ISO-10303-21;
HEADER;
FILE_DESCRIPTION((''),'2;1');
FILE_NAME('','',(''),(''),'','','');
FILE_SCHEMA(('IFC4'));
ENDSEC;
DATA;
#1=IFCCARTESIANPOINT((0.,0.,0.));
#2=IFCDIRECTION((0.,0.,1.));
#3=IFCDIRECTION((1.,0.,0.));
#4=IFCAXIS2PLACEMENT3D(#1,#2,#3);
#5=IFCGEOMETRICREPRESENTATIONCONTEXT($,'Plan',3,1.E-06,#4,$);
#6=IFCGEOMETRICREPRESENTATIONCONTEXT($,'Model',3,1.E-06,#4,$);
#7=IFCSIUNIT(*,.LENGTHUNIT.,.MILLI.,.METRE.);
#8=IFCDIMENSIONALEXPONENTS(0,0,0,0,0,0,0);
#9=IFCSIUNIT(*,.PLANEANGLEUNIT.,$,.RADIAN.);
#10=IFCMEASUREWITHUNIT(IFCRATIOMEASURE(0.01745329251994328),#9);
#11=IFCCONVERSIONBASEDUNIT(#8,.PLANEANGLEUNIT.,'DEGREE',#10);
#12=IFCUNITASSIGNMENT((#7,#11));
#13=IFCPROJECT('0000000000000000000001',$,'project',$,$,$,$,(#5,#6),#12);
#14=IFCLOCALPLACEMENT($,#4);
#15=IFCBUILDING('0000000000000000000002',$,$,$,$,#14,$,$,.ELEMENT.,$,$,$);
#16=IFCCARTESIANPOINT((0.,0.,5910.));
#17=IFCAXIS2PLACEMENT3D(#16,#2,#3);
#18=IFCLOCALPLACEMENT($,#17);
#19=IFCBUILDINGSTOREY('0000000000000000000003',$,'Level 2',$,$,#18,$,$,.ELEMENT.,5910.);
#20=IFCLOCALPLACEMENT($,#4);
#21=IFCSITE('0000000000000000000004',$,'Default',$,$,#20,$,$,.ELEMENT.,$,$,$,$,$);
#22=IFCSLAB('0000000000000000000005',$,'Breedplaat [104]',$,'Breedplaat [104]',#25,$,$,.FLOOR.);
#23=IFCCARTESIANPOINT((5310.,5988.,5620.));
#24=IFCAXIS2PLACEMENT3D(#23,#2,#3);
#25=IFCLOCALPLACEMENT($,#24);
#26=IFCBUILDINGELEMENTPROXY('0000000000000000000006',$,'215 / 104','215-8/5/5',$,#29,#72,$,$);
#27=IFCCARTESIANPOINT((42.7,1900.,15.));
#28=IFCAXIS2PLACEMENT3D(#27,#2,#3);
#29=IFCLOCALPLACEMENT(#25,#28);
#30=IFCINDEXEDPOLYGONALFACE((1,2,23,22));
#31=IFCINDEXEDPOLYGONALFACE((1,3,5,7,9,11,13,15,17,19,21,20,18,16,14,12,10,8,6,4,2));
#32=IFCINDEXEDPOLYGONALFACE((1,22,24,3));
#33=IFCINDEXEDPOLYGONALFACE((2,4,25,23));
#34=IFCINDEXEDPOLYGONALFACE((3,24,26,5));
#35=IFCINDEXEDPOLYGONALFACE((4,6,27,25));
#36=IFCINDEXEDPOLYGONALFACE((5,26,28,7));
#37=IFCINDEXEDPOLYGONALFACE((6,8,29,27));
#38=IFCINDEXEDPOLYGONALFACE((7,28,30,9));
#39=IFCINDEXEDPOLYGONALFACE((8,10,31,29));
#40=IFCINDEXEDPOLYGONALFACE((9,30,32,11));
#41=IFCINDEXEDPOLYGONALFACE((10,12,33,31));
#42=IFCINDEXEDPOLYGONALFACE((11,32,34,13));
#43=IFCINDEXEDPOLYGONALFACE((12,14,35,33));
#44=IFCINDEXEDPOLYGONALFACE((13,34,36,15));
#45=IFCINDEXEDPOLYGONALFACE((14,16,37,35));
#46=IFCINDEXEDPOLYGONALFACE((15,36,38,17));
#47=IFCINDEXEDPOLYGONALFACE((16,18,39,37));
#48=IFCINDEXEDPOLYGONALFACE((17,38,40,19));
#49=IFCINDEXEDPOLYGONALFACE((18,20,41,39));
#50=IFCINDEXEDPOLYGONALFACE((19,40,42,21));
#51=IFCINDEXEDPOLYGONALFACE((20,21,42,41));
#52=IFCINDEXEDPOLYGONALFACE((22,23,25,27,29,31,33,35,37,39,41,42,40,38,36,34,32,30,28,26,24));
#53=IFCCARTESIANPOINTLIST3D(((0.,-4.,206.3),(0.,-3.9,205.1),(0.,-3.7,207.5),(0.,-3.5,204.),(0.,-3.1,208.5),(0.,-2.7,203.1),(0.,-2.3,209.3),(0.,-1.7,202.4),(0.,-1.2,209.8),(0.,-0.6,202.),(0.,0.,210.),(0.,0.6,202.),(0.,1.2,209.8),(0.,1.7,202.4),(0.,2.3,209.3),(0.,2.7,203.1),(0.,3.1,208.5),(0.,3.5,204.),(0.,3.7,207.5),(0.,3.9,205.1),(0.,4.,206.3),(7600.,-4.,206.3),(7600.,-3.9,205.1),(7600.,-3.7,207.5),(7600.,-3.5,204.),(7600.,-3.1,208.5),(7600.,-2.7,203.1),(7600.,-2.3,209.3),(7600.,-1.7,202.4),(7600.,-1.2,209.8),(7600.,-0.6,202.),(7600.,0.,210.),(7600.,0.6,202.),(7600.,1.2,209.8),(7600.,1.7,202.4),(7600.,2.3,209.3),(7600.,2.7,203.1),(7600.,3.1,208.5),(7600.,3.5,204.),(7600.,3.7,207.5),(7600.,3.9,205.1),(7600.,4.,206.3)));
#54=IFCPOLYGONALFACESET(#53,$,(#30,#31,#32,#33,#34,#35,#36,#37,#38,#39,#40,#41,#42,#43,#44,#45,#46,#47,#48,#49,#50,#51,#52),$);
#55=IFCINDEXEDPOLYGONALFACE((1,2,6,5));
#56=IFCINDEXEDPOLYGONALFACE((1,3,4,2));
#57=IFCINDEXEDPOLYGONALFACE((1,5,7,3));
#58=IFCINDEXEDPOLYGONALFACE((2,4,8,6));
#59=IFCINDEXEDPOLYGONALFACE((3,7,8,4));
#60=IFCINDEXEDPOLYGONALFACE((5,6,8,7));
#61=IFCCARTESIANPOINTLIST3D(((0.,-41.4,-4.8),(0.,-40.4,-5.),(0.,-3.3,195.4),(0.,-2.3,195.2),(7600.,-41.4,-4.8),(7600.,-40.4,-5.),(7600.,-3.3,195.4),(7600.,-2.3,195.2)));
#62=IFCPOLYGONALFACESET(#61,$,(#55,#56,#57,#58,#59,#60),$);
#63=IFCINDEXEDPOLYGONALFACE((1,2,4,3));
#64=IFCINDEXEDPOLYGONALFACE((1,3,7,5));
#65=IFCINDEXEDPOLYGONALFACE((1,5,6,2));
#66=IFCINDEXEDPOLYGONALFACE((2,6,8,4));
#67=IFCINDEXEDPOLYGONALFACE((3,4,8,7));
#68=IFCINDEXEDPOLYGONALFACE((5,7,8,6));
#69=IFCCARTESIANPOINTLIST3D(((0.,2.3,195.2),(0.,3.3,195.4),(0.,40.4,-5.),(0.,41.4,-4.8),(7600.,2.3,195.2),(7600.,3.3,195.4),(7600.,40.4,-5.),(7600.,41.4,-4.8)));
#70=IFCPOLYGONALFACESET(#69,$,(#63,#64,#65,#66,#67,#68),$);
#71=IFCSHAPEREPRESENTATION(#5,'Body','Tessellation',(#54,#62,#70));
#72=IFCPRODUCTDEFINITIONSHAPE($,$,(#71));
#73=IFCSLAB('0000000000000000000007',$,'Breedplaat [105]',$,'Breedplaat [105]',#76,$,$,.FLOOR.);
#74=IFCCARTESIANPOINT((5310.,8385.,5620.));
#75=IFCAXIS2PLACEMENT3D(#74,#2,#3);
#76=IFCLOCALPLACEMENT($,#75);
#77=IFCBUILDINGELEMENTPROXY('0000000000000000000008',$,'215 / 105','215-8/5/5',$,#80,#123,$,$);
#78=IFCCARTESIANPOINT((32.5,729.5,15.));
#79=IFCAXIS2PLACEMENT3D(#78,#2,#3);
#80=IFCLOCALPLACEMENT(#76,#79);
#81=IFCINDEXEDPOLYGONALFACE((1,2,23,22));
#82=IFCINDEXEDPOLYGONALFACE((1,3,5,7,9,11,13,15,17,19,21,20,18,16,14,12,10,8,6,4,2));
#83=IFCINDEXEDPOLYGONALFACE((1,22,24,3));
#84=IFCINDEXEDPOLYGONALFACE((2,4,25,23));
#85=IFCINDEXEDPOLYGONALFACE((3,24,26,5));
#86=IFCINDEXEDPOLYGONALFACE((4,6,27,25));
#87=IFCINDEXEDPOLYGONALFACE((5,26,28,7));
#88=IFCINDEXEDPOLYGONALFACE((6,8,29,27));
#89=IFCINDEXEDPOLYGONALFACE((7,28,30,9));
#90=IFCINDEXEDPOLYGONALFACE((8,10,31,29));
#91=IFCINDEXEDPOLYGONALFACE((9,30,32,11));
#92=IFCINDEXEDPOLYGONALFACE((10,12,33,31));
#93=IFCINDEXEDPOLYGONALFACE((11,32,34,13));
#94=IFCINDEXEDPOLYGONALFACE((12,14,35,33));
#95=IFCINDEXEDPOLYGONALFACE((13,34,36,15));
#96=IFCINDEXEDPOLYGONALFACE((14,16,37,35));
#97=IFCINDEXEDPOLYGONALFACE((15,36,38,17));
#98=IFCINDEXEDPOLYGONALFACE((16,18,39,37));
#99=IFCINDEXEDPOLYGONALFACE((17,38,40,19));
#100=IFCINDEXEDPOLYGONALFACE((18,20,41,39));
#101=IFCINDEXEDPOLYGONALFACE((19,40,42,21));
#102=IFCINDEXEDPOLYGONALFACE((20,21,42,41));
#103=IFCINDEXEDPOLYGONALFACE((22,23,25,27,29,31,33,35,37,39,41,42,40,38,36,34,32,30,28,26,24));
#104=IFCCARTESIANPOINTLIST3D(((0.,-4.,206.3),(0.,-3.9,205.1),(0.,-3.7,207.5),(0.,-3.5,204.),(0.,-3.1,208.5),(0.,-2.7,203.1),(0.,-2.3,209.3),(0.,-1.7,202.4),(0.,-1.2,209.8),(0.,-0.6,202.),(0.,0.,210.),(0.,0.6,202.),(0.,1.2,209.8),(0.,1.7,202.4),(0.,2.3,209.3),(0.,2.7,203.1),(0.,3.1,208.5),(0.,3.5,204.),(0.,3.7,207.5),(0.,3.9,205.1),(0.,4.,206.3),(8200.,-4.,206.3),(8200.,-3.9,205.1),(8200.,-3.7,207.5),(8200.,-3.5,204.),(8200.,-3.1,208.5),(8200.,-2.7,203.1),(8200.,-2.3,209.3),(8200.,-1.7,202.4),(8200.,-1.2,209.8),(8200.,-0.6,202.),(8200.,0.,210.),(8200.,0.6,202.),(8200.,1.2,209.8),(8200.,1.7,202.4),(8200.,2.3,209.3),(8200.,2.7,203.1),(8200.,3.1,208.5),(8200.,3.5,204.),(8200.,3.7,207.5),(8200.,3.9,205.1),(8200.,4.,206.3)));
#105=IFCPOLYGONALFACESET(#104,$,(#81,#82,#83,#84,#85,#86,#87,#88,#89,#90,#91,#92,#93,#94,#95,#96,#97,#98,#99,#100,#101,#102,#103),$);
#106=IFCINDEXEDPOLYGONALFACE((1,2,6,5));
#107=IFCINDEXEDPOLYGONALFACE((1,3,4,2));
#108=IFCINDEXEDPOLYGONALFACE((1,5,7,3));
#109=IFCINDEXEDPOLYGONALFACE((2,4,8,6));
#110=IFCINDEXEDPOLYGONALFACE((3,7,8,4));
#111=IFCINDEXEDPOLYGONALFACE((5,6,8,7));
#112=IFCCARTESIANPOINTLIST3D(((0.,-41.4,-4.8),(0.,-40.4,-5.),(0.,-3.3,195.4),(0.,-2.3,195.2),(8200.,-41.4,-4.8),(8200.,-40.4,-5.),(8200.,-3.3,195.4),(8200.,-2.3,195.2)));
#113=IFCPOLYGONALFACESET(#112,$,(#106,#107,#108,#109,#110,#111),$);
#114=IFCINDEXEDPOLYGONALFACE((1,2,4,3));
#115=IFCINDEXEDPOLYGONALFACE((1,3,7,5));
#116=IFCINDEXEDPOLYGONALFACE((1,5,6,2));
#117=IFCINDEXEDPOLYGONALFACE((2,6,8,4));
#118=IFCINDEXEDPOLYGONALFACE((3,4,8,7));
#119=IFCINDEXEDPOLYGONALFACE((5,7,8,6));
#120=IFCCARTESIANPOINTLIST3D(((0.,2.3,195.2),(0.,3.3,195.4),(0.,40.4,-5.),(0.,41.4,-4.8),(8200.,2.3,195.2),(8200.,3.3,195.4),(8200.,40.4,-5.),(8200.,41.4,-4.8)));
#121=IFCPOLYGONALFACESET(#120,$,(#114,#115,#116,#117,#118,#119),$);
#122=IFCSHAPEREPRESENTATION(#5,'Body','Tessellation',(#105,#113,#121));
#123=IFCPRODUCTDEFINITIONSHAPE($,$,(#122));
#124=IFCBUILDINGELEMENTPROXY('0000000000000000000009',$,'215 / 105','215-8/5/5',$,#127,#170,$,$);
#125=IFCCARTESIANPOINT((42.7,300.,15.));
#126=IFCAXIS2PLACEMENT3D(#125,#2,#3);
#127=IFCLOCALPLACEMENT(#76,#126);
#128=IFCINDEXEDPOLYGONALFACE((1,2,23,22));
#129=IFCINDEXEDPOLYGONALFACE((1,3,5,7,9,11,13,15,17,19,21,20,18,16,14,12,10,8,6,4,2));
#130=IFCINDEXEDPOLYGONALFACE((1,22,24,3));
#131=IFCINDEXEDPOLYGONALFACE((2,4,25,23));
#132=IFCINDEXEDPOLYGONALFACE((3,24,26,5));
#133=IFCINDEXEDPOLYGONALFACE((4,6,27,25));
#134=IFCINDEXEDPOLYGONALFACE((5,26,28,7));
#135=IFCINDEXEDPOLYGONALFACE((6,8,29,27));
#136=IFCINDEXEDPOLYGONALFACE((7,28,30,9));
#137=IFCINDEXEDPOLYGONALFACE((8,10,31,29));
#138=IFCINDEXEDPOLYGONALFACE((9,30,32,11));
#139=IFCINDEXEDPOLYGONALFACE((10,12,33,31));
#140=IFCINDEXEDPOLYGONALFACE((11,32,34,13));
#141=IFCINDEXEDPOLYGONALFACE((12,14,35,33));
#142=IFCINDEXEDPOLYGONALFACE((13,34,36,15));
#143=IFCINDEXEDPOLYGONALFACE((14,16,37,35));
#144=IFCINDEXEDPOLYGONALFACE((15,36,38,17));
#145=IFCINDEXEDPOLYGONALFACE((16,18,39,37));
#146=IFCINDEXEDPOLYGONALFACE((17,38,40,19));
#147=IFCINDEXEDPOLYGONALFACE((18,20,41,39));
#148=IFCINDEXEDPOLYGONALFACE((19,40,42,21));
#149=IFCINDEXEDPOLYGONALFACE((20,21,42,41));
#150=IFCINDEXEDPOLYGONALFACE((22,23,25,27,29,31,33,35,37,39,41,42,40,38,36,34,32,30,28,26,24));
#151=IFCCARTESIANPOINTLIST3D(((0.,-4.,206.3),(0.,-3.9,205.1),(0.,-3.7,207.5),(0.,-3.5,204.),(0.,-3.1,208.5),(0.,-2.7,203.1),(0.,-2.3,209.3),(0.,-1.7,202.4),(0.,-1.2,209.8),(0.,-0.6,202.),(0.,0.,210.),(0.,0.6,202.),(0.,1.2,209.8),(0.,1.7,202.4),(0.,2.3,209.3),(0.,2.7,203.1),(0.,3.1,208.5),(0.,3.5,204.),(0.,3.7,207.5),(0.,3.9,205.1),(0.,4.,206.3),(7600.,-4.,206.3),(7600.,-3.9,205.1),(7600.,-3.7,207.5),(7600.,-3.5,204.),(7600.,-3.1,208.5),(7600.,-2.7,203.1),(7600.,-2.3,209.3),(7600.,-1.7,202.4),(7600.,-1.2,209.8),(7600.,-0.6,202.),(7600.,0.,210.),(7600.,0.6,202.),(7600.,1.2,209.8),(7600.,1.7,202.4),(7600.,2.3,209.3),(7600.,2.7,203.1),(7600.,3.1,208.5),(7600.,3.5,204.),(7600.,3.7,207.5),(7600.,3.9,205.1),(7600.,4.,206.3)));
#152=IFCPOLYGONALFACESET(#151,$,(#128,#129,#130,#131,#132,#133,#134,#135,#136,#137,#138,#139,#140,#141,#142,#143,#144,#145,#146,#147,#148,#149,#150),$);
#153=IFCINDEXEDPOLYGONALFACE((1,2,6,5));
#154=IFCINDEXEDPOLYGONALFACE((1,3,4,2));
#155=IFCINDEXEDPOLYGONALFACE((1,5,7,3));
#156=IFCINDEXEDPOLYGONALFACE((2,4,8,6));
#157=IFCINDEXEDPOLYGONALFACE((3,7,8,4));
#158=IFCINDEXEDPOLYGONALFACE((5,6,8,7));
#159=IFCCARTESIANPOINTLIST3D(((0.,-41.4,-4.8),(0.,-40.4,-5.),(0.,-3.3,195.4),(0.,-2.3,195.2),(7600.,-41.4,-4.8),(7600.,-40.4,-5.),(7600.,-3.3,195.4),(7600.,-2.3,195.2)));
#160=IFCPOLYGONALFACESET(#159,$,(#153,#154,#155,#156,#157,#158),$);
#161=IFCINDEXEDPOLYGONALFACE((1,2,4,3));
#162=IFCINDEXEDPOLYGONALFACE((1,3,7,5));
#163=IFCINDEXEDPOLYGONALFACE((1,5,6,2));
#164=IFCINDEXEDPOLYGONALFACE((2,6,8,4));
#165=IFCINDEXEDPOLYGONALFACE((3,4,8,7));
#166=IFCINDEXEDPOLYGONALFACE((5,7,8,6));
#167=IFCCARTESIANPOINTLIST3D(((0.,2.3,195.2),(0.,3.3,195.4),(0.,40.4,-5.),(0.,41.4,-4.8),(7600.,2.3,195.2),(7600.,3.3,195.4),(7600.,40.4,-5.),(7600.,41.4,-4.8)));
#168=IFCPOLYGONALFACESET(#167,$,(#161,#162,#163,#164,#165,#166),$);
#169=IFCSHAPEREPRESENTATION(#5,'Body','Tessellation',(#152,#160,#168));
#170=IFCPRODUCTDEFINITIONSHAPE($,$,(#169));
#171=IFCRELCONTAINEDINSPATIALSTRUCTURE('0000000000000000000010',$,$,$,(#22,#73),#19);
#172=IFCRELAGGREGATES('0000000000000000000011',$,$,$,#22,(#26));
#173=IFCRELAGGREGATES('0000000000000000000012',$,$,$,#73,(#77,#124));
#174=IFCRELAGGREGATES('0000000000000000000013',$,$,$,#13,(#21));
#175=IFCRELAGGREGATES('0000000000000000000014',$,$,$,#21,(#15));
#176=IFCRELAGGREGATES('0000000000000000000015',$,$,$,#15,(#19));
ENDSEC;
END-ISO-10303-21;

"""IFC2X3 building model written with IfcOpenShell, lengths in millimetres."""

from ifc_helpers import new_model, entity, si_unit, converted_unit, frame, origin_with_axes, origin_2d_with_axis, place, context, project, spatial, rectangle, circle, extrude, element, aggregate, save


model = new_model("IFC2X3")

# Units and contexts
plan_context = context("Plan", 3, precision=1e-06, world=origin_with_axes())
model_context = context("Model", 3, precision=1e-06, world=origin_with_axes())
ifc_project = project(units=[si_unit("LENGTHUNIT", "METRE", prefix="MILLI"), converted_unit("PLANEANGLEUNIT", "DEGREE", entity("IfcRatioMeasure", 0.01745329251994328), si_unit("PLANEANGLEUNIT", "RADIAN"), dimensions=[0, 0, 0, 0, 0, 0, 0])], contexts=[plan_context, model_context])

# Site, building, storey
site_placement = place(None, origin_with_axes())
site = spatial("IfcSite", under=ifc_project, at=site_placement, Name="Default", CompositionType="ELEMENT")
building_placement = place(None, origin_with_axes())
building = spatial("IfcBuilding", under=site, at=building_placement, CompositionType="ELEMENT")
storey_placement = place(None, frame((0.0, 0.0, 5910.0), z_axis=(0.0, 0.0, 1.0), x_axis=(1.0, 0.0, 0.0)))
storey = spatial("IfcBuildingStorey", under=building, at=storey_placement, Name="Level 2", CompositionType="ELEMENT", Elevation=5910.0)

# Slabs, building element proxies
slab_1_placement = place(None, frame((5310.0, 5988.0, 5620.0), z_axis=(0.0, 0.0, 1.0), x_axis=(1.0, 0.0, 0.0)))
slab_1 = element("IfcSlab", 1, at=slab_1_placement, inside=storey, Name="Breedplaat [104]", ObjectType="Breedplaat [104]", PredefinedType="FLOOR")
proxy_1_placement = place(slab_1_placement, frame((42.7, 1900.0, 15.0), z_axis=(0.0, 0.0, 1.0), x_axis=(1.0, 0.0, 0.0)))
proxy_1 = element("IfcBuildingElementProxy", 2, at=proxy_1_placement, Name="215 / 104", Description="215-8/5/5", context=plan_context, shape_type="SweptSolid", body=[
    extrude(circle(Radius=4.0, at=origin_2d_with_axis()), frame((0.0, 0.0, 206.0), z_axis=(1.0, 0.0, 0.0), x_axis=(0.0, 0.0, 1.0)), (0.0, 0.0, 1.0), 7600.0),
    extrude(rectangle(XDim=203.8, YDim=1.0, at=origin_2d_with_axis()), frame((0.0, -21.9, 95.2), z_axis=(1.0, 0.0, 0.0), x_axis=(0.0, 0.187112, 0.982339)), (0.0, 0.0, 1.0), 7600.0),
    extrude(rectangle(XDim=203.8, YDim=1.0, at=origin_2d_with_axis()), frame((0.0, 21.9, 95.2), z_axis=(1.0, 0.0, 0.0), x_axis=(0.0, -0.187112, 0.982339)), (0.0, 0.0, 1.0), 7600.0),
])
aggregate(slab_1, [proxy_1])
slab_2_placement = place(None, frame((5310.0, 8385.0, 5620.0), z_axis=(0.0, 0.0, 1.0), x_axis=(1.0, 0.0, 0.0)))
slab_2 = element("IfcSlab", 3, at=slab_2_placement, inside=storey, Name="Breedplaat [105]", ObjectType="Breedplaat [105]", PredefinedType="FLOOR")
proxy_2_placement = place(slab_2_placement, frame((32.5, 729.5, 15.0), z_axis=(0.0, 0.0, 1.0), x_axis=(1.0, 0.0, 0.0)))
proxy_2 = element("IfcBuildingElementProxy", 4, at=proxy_2_placement, Name="215 / 105", Description="215-8/5/5", context=plan_context, shape_type="SweptSolid", body=[
    extrude(circle(Radius=4.0, at=origin_2d_with_axis()), frame((0.0, 0.0, 206.0), z_axis=(1.0, 0.0, 0.0), x_axis=(0.0, 0.0, 1.0)), (0.0, 0.0, 1.0), 8200.0),
    extrude(rectangle(XDim=203.8, YDim=1.0, at=origin_2d_with_axis()), frame((0.0, -21.9, 95.2), z_axis=(1.0, 0.0, 0.0), x_axis=(0.0, 0.187112, 0.982339)), (0.0, 0.0, 1.0), 8200.0),
    extrude(rectangle(XDim=203.8, YDim=1.0, at=origin_2d_with_axis()), frame((0.0, 21.9, 95.2), z_axis=(1.0, 0.0, 0.0), x_axis=(0.0, -0.187112, 0.982339)), (0.0, 0.0, 1.0), 8200.0),
])
proxy_3_placement = place(slab_2_placement, frame((42.7, 300.0, 15.0), z_axis=(0.0, 0.0, 1.0), x_axis=(1.0, 0.0, 0.0)))
proxy_3 = element("IfcBuildingElementProxy", 5, at=proxy_3_placement, Name="215 / 105", Description="215-8/5/5", context=plan_context, shape_type="SweptSolid", body=[
    extrude(circle(Radius=4.0, at=origin_2d_with_axis()), frame((0.0, 0.0, 206.0), z_axis=(1.0, 0.0, 0.0), x_axis=(0.0, 0.0, 1.0)), (0.0, 0.0, 1.0), 7600.0),
    extrude(rectangle(XDim=203.8, YDim=1.0, at=origin_2d_with_axis()), frame((0.0, -21.9, 95.2), z_axis=(1.0, 0.0, 0.0), x_axis=(0.0, 0.187112, 0.982339)), (0.0, 0.0, 1.0), 7600.0),
    extrude(rectangle(XDim=203.8, YDim=1.0, at=origin_2d_with_axis()), frame((0.0, 21.9, 95.2), z_axis=(1.0, 0.0, 0.0), x_axis=(0.0, -0.187112, 0.982339)), (0.0, 0.0, 1.0), 7600.0),
])
aggregate(slab_2, [proxy_2, proxy_3])

save(model, "model.ifc")
